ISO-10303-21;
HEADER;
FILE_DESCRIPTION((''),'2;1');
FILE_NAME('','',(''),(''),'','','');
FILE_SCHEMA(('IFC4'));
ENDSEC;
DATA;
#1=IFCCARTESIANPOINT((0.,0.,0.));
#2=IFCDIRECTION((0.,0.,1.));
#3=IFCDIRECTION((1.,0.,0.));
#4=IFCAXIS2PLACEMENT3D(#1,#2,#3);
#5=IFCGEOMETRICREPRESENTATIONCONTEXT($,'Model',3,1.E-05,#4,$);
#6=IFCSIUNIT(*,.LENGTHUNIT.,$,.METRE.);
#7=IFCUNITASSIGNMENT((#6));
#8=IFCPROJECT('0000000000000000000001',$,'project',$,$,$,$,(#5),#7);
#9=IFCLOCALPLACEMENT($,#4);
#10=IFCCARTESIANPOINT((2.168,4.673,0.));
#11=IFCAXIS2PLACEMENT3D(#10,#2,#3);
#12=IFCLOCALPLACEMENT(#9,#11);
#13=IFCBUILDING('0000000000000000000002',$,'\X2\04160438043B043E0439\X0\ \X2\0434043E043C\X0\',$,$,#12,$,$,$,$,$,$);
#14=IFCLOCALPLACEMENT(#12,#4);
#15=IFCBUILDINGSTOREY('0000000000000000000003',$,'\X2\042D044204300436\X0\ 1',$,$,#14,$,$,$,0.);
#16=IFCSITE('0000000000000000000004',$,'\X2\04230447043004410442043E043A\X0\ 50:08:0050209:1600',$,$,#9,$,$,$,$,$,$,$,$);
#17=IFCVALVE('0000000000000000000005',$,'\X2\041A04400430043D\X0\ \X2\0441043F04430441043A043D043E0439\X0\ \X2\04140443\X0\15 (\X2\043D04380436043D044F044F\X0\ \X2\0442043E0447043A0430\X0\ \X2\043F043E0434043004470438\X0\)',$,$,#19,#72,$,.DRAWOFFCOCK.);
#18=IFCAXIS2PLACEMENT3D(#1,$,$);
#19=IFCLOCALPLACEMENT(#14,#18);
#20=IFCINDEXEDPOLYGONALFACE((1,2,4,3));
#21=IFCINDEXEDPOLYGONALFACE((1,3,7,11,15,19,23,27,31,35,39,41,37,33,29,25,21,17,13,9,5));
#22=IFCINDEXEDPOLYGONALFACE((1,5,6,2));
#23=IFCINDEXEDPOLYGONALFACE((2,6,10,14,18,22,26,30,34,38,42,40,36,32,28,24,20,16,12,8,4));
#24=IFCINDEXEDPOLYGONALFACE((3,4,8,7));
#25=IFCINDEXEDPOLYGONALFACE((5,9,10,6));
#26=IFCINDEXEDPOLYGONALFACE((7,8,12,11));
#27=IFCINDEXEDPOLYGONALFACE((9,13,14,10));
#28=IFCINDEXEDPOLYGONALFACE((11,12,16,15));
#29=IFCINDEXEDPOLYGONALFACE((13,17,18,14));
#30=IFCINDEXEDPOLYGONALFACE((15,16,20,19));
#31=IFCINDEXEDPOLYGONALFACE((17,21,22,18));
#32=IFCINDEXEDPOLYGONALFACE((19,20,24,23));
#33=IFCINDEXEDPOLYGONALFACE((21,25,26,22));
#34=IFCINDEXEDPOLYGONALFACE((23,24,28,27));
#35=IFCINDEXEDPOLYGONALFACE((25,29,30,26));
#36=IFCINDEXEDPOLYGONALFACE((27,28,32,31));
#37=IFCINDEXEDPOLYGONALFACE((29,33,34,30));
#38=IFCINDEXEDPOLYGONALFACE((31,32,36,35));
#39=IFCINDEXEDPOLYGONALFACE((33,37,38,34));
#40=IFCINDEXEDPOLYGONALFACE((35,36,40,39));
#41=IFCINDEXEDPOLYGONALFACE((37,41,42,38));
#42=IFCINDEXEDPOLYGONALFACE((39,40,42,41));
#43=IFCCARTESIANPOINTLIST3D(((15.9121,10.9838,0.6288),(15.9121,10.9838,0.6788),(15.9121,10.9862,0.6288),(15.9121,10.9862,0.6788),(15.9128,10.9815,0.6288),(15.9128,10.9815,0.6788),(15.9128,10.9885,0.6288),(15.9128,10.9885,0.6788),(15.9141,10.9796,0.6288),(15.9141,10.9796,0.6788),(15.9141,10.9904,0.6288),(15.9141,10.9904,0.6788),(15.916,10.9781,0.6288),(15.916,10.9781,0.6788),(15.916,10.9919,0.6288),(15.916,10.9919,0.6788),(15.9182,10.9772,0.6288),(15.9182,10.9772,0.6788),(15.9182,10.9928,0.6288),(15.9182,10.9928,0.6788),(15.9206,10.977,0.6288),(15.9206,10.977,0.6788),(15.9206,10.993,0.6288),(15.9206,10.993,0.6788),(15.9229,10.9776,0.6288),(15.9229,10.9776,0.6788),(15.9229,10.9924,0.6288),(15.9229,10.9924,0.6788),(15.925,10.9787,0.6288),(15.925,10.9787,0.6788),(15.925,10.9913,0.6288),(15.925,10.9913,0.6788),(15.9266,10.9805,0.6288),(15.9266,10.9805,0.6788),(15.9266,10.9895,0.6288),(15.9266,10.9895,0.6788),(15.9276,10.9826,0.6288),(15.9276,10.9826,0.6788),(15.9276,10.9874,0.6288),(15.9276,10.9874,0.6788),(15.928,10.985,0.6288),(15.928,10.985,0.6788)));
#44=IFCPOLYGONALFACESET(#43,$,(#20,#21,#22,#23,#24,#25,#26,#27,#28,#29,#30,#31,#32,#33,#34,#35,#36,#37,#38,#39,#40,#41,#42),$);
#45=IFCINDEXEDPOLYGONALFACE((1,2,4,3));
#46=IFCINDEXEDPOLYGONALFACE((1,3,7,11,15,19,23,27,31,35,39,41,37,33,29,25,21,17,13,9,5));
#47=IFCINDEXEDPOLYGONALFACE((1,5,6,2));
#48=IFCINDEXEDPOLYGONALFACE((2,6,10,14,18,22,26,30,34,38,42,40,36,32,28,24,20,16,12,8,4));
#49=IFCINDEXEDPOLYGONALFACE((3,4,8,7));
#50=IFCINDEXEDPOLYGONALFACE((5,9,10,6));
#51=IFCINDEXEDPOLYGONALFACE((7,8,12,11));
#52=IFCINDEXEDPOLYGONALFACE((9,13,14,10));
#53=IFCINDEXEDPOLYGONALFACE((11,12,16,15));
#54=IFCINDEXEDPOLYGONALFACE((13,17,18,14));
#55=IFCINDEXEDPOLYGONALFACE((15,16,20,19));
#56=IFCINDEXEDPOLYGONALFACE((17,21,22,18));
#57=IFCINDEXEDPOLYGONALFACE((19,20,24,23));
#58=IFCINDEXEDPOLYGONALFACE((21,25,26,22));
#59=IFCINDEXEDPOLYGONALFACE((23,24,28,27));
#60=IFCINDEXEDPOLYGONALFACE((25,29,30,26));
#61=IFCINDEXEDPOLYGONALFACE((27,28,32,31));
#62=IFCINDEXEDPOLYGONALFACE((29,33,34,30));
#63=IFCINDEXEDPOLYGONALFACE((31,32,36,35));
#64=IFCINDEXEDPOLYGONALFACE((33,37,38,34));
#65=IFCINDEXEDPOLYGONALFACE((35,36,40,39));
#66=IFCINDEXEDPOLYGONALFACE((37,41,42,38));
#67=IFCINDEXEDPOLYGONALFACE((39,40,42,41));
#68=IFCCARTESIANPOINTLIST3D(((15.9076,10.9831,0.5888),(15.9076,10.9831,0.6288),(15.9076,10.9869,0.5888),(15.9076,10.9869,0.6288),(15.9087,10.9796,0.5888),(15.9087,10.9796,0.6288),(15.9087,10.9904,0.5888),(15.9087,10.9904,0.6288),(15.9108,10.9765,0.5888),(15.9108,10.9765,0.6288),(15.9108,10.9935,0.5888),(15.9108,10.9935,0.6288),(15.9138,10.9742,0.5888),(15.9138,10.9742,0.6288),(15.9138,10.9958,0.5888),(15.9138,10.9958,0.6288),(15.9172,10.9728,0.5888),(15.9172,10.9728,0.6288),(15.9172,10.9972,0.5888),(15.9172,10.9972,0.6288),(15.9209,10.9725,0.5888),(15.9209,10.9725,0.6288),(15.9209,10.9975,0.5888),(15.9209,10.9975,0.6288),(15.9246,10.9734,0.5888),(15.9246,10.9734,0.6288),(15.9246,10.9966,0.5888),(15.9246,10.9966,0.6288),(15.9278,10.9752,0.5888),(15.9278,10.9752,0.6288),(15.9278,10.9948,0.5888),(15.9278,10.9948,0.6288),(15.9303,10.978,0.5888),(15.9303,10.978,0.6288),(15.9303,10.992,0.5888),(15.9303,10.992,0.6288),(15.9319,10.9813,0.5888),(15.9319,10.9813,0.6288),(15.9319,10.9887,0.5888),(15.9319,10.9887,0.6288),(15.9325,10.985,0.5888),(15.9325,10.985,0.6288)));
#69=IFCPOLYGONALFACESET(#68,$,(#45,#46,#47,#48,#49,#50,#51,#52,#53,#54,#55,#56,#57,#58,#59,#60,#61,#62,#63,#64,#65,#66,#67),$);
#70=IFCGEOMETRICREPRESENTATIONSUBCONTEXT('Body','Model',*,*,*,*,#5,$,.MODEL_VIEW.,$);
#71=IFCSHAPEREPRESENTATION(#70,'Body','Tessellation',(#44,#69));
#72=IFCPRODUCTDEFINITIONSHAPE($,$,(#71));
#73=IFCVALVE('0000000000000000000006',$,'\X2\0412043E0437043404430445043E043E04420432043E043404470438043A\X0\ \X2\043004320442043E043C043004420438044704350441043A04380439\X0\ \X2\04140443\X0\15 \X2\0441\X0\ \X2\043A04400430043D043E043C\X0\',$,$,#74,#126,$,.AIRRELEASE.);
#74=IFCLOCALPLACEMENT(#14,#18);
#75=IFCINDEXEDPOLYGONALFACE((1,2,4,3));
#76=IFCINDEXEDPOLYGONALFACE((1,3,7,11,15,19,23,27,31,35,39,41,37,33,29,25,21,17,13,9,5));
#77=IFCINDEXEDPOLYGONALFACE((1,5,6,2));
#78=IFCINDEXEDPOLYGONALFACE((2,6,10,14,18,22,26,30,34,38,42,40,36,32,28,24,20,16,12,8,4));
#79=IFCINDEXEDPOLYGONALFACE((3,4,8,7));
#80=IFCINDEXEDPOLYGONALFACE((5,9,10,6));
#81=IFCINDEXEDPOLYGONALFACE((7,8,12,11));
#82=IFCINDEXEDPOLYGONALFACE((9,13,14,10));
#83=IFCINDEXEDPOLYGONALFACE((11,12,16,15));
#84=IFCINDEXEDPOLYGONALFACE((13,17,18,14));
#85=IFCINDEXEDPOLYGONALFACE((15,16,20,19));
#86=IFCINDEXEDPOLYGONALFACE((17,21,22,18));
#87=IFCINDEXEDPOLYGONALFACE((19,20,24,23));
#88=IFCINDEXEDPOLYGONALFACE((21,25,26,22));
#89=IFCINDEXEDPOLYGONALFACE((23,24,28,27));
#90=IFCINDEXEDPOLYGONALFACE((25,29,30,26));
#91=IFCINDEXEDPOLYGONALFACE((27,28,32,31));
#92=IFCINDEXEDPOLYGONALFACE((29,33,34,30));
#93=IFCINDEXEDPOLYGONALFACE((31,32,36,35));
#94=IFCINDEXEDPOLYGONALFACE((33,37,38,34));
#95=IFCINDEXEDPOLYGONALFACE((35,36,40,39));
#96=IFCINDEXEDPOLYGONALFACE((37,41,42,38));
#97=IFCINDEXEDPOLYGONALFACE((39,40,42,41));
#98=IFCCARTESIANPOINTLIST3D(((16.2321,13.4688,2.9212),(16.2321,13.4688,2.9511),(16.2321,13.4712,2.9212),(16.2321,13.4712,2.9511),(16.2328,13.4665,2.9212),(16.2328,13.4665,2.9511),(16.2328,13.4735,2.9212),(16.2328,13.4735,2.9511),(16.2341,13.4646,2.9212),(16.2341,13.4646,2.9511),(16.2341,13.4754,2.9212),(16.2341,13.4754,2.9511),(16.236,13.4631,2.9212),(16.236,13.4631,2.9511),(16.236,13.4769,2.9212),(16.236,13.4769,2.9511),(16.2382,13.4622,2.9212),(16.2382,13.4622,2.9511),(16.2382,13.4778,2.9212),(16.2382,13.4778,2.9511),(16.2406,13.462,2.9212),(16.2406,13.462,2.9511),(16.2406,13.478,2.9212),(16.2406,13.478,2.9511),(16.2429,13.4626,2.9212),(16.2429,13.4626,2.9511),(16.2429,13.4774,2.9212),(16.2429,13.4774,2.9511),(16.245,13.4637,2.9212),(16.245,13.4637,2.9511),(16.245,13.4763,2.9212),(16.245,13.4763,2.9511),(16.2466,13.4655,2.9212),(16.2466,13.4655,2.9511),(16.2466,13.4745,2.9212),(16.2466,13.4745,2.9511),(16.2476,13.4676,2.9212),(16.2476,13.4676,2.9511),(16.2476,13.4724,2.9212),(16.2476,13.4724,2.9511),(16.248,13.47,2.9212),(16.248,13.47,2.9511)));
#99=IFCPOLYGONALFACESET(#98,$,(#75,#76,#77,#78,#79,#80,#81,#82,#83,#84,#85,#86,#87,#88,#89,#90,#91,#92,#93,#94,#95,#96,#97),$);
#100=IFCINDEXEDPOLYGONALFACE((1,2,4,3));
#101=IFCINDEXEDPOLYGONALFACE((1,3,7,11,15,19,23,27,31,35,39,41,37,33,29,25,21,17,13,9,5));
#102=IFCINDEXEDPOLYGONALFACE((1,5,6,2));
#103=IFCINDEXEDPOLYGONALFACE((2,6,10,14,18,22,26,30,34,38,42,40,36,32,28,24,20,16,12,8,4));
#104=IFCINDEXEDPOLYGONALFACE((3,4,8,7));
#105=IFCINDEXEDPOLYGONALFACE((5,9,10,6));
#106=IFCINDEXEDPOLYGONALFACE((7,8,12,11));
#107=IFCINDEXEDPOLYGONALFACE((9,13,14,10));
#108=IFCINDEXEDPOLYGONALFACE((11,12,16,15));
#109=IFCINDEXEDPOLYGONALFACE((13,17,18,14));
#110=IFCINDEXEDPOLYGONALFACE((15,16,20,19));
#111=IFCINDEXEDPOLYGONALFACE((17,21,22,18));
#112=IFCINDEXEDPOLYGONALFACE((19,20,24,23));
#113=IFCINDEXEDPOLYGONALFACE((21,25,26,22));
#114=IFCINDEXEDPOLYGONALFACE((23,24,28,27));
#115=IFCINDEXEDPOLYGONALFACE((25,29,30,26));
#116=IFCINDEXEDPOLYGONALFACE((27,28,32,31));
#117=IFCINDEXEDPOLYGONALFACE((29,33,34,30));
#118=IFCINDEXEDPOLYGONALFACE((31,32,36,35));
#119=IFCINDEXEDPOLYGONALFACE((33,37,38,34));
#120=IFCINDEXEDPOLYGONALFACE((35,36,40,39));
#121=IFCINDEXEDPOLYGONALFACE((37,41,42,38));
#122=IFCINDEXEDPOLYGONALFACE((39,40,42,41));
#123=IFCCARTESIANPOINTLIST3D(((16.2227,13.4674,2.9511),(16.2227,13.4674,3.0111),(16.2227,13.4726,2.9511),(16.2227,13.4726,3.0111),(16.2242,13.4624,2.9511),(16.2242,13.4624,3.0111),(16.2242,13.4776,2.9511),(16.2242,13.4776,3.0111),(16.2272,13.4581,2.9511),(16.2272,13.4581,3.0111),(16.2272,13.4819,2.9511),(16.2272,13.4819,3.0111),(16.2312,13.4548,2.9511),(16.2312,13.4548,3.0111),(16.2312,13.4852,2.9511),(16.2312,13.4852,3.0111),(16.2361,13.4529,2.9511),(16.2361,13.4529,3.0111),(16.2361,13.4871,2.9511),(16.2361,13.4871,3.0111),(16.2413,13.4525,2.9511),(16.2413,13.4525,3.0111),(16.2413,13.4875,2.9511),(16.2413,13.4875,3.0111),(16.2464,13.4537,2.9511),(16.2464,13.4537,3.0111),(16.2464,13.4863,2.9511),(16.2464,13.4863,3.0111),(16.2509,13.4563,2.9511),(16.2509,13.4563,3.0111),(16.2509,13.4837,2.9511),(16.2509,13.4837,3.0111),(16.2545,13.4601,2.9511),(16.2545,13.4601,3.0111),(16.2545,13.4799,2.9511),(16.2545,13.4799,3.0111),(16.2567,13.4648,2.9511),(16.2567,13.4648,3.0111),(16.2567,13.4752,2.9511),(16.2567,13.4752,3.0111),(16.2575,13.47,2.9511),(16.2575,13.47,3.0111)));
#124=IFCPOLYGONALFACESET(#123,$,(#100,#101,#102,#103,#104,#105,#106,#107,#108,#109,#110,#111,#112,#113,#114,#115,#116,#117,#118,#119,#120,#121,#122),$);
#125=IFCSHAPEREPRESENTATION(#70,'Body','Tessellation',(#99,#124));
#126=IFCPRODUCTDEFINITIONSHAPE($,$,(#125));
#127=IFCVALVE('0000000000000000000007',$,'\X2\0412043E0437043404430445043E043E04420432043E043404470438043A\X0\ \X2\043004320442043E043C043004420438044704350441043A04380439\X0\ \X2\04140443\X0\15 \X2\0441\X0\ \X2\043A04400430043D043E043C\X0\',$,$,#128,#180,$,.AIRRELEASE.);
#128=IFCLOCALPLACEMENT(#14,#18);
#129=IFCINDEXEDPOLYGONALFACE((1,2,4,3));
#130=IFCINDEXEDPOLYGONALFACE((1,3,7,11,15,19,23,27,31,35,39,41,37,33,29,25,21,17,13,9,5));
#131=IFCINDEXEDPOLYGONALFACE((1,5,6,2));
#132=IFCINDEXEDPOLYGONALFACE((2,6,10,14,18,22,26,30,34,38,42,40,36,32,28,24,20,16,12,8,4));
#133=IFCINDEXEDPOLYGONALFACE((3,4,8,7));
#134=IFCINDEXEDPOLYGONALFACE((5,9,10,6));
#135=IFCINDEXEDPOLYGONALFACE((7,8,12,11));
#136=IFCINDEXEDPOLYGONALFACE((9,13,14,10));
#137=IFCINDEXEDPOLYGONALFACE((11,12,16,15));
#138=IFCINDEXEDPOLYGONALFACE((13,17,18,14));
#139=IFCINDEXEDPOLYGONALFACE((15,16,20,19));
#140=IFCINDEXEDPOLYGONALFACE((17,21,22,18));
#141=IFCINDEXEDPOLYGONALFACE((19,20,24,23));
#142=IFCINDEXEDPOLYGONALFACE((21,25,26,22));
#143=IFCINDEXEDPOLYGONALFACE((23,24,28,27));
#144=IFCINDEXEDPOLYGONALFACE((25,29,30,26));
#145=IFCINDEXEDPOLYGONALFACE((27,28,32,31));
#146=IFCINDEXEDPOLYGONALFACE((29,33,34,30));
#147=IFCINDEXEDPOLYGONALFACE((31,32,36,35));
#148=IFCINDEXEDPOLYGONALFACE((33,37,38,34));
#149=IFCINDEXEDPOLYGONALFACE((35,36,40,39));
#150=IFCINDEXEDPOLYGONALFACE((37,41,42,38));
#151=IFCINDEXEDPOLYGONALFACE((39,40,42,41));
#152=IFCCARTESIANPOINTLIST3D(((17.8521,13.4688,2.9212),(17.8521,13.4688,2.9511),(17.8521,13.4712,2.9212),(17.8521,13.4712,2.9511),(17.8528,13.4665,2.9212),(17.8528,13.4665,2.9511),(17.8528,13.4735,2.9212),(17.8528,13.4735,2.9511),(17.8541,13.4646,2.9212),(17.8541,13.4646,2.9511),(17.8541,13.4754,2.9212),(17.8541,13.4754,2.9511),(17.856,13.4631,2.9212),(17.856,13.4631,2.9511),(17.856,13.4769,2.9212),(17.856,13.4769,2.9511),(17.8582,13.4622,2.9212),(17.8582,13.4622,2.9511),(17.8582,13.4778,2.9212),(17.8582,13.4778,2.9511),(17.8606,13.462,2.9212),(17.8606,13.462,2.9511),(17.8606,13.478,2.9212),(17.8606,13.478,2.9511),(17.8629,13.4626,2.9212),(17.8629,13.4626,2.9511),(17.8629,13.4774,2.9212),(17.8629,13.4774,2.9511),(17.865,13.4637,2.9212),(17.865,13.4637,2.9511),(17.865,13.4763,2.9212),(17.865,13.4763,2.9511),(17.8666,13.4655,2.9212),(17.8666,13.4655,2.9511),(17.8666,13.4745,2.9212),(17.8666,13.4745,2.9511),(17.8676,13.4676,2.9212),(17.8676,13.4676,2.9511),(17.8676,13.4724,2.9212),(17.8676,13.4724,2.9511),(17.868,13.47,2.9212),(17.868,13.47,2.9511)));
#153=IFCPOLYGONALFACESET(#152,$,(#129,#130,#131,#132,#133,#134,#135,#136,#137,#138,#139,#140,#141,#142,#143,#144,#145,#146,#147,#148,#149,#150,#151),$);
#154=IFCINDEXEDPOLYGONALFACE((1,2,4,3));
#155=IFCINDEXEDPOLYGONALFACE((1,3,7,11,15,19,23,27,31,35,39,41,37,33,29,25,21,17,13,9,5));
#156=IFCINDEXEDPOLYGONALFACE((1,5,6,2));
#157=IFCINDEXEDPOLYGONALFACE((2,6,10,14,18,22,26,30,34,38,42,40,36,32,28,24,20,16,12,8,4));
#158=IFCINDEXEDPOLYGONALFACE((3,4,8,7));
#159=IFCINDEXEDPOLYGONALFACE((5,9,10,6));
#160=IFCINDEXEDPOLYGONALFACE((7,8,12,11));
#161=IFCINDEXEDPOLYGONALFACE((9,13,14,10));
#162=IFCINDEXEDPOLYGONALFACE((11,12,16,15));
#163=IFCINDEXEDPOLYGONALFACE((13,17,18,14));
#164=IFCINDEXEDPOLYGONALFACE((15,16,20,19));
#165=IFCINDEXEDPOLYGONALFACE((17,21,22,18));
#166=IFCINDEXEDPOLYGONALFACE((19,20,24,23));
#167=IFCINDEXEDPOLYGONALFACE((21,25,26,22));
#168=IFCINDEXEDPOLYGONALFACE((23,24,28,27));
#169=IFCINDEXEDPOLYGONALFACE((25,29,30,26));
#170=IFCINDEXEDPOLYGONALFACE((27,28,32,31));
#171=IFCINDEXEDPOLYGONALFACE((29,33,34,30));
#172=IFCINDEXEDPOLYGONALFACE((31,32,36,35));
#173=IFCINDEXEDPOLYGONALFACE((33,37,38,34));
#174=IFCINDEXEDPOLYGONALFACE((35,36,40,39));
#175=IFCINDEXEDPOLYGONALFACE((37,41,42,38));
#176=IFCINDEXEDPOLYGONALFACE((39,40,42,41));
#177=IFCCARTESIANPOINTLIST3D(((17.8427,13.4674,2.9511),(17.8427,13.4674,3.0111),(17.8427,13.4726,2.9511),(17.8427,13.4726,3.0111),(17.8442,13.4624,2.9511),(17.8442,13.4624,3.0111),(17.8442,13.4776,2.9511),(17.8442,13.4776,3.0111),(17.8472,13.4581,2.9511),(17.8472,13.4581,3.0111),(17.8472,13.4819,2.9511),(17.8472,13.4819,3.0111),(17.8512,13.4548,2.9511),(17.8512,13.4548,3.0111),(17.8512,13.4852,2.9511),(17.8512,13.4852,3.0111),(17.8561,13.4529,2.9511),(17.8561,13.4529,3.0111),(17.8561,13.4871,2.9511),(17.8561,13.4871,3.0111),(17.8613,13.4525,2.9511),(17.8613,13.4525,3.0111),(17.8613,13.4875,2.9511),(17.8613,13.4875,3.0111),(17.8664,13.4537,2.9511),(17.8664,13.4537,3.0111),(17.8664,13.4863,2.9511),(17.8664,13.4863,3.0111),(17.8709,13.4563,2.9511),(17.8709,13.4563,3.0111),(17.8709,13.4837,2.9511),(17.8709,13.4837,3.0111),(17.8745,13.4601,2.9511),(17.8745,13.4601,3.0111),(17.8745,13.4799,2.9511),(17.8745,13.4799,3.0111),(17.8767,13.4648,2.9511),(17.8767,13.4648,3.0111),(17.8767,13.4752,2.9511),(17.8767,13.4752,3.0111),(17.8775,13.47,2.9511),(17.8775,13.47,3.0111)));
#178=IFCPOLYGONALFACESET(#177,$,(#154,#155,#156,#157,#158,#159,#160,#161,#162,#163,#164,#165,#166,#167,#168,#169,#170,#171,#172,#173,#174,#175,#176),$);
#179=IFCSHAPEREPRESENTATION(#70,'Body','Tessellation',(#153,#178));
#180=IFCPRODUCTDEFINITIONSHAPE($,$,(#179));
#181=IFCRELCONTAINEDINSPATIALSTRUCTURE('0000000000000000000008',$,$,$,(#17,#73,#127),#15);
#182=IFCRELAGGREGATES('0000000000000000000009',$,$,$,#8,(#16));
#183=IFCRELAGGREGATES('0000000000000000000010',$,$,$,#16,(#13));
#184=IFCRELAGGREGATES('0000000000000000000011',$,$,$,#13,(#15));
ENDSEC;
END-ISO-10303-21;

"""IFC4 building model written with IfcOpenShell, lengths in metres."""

from ifc_helpers import new_model, si_unit, frame, origin_with_axes, origin_2d, place, context, subcontext, project, spatial, circle, extrude, element, save


model = new_model("IFC4")

# Units and contexts
model_context = context("Model", 3, precision=1e-05, world=origin_with_axes())
body_context = subcontext(model_context, "Body", "Model", "MODEL_VIEW")
ifc_project = project(units=[si_unit("LENGTHUNIT", "METRE")], contexts=[model_context])

# Site, building, storey
site_placement = place(None, origin_with_axes())
site = spatial("IfcSite", under=ifc_project, at=site_placement, Name="Участок 50:08:0050209:1600")
building_placement = place(site_placement, frame((2.168, 4.673, 0.0), z_axis=(0.0, 0.0, 1.0), x_axis=(1.0, 0.0, 0.0)))
building = spatial("IfcBuilding", under=site, at=building_placement, Name="Жилой дом")
storey_placement = place(building_placement, origin_with_axes())
storey = spatial("IfcBuildingStorey", under=building, at=storey_placement, Name="Этаж 1", Elevation=0.0)

# Valves
valve_1_placement = place(storey_placement, origin_with_axes())
element("IfcValve", 1, at=valve_1_placement, inside=storey, Name="Кран спускной Ду15 (нижняя точка подачи)", PredefinedType="DRAWOFFCOCK", context=body_context, shape_type="SweptSolid", body=[
    extrude(circle(Radius=0.008, at=origin_2d()), frame((15.92, 10.985, 0.6788), z_axis=(0.0, 0.0, -1.0), x_axis=(1.0, 0.0, 0.0)), (0.0, 0.0, 1.0), 0.05),
    extrude(circle(Radius=0.0125, at=origin_2d()), frame((15.92, 10.985, 0.6288), z_axis=(0.0, 0.0, -1.0), x_axis=(1.0, 0.0, 0.0)), (0.0, 0.0, 1.0), 0.04),
])
valve_2_placement = place(storey_placement, origin_with_axes())
element("IfcValve", 2, at=valve_2_placement, inside=storey, Name="Воздухоотводчик автоматический Ду15 с краном", PredefinedType="AIRRELEASE", context=body_context, shape_type="SweptSolid", body=[
    extrude(circle(Radius=0.008, at=origin_2d()), frame((16.24, 13.47, 2.9211), z_axis=(0.0, 0.0, 1.0), x_axis=(1.0, 0.0, 0.0)), (0.0, 0.0, 1.0), 0.03),
    extrude(circle(Radius=0.0175, at=origin_2d()), frame((16.24, 13.47, 2.9511), z_axis=(0.0, 0.0, 1.0), x_axis=(1.0, 0.0, 0.0)), (0.0, 0.0, 1.0), 0.06),
])
valve_3_placement = place(storey_placement, origin_with_axes())
element("IfcValve", 3, at=valve_3_placement, inside=storey, Name="Воздухоотводчик автоматический Ду15 с краном", PredefinedType="AIRRELEASE", context=body_context, shape_type="SweptSolid", body=[
    extrude(circle(Radius=0.008, at=origin_2d()), frame((17.86, 13.47, 2.9211), z_axis=(0.0, 0.0, 1.0), x_axis=(1.0, 0.0, 0.0)), (0.0, 0.0, 1.0), 0.03),
    extrude(circle(Radius=0.0175, at=origin_2d()), frame((17.86, 13.47, 2.9511), z_axis=(0.0, 0.0, 1.0), x_axis=(1.0, 0.0, 0.0)), (0.0, 0.0, 1.0), 0.06),
])

save(model, "model.ifc")
